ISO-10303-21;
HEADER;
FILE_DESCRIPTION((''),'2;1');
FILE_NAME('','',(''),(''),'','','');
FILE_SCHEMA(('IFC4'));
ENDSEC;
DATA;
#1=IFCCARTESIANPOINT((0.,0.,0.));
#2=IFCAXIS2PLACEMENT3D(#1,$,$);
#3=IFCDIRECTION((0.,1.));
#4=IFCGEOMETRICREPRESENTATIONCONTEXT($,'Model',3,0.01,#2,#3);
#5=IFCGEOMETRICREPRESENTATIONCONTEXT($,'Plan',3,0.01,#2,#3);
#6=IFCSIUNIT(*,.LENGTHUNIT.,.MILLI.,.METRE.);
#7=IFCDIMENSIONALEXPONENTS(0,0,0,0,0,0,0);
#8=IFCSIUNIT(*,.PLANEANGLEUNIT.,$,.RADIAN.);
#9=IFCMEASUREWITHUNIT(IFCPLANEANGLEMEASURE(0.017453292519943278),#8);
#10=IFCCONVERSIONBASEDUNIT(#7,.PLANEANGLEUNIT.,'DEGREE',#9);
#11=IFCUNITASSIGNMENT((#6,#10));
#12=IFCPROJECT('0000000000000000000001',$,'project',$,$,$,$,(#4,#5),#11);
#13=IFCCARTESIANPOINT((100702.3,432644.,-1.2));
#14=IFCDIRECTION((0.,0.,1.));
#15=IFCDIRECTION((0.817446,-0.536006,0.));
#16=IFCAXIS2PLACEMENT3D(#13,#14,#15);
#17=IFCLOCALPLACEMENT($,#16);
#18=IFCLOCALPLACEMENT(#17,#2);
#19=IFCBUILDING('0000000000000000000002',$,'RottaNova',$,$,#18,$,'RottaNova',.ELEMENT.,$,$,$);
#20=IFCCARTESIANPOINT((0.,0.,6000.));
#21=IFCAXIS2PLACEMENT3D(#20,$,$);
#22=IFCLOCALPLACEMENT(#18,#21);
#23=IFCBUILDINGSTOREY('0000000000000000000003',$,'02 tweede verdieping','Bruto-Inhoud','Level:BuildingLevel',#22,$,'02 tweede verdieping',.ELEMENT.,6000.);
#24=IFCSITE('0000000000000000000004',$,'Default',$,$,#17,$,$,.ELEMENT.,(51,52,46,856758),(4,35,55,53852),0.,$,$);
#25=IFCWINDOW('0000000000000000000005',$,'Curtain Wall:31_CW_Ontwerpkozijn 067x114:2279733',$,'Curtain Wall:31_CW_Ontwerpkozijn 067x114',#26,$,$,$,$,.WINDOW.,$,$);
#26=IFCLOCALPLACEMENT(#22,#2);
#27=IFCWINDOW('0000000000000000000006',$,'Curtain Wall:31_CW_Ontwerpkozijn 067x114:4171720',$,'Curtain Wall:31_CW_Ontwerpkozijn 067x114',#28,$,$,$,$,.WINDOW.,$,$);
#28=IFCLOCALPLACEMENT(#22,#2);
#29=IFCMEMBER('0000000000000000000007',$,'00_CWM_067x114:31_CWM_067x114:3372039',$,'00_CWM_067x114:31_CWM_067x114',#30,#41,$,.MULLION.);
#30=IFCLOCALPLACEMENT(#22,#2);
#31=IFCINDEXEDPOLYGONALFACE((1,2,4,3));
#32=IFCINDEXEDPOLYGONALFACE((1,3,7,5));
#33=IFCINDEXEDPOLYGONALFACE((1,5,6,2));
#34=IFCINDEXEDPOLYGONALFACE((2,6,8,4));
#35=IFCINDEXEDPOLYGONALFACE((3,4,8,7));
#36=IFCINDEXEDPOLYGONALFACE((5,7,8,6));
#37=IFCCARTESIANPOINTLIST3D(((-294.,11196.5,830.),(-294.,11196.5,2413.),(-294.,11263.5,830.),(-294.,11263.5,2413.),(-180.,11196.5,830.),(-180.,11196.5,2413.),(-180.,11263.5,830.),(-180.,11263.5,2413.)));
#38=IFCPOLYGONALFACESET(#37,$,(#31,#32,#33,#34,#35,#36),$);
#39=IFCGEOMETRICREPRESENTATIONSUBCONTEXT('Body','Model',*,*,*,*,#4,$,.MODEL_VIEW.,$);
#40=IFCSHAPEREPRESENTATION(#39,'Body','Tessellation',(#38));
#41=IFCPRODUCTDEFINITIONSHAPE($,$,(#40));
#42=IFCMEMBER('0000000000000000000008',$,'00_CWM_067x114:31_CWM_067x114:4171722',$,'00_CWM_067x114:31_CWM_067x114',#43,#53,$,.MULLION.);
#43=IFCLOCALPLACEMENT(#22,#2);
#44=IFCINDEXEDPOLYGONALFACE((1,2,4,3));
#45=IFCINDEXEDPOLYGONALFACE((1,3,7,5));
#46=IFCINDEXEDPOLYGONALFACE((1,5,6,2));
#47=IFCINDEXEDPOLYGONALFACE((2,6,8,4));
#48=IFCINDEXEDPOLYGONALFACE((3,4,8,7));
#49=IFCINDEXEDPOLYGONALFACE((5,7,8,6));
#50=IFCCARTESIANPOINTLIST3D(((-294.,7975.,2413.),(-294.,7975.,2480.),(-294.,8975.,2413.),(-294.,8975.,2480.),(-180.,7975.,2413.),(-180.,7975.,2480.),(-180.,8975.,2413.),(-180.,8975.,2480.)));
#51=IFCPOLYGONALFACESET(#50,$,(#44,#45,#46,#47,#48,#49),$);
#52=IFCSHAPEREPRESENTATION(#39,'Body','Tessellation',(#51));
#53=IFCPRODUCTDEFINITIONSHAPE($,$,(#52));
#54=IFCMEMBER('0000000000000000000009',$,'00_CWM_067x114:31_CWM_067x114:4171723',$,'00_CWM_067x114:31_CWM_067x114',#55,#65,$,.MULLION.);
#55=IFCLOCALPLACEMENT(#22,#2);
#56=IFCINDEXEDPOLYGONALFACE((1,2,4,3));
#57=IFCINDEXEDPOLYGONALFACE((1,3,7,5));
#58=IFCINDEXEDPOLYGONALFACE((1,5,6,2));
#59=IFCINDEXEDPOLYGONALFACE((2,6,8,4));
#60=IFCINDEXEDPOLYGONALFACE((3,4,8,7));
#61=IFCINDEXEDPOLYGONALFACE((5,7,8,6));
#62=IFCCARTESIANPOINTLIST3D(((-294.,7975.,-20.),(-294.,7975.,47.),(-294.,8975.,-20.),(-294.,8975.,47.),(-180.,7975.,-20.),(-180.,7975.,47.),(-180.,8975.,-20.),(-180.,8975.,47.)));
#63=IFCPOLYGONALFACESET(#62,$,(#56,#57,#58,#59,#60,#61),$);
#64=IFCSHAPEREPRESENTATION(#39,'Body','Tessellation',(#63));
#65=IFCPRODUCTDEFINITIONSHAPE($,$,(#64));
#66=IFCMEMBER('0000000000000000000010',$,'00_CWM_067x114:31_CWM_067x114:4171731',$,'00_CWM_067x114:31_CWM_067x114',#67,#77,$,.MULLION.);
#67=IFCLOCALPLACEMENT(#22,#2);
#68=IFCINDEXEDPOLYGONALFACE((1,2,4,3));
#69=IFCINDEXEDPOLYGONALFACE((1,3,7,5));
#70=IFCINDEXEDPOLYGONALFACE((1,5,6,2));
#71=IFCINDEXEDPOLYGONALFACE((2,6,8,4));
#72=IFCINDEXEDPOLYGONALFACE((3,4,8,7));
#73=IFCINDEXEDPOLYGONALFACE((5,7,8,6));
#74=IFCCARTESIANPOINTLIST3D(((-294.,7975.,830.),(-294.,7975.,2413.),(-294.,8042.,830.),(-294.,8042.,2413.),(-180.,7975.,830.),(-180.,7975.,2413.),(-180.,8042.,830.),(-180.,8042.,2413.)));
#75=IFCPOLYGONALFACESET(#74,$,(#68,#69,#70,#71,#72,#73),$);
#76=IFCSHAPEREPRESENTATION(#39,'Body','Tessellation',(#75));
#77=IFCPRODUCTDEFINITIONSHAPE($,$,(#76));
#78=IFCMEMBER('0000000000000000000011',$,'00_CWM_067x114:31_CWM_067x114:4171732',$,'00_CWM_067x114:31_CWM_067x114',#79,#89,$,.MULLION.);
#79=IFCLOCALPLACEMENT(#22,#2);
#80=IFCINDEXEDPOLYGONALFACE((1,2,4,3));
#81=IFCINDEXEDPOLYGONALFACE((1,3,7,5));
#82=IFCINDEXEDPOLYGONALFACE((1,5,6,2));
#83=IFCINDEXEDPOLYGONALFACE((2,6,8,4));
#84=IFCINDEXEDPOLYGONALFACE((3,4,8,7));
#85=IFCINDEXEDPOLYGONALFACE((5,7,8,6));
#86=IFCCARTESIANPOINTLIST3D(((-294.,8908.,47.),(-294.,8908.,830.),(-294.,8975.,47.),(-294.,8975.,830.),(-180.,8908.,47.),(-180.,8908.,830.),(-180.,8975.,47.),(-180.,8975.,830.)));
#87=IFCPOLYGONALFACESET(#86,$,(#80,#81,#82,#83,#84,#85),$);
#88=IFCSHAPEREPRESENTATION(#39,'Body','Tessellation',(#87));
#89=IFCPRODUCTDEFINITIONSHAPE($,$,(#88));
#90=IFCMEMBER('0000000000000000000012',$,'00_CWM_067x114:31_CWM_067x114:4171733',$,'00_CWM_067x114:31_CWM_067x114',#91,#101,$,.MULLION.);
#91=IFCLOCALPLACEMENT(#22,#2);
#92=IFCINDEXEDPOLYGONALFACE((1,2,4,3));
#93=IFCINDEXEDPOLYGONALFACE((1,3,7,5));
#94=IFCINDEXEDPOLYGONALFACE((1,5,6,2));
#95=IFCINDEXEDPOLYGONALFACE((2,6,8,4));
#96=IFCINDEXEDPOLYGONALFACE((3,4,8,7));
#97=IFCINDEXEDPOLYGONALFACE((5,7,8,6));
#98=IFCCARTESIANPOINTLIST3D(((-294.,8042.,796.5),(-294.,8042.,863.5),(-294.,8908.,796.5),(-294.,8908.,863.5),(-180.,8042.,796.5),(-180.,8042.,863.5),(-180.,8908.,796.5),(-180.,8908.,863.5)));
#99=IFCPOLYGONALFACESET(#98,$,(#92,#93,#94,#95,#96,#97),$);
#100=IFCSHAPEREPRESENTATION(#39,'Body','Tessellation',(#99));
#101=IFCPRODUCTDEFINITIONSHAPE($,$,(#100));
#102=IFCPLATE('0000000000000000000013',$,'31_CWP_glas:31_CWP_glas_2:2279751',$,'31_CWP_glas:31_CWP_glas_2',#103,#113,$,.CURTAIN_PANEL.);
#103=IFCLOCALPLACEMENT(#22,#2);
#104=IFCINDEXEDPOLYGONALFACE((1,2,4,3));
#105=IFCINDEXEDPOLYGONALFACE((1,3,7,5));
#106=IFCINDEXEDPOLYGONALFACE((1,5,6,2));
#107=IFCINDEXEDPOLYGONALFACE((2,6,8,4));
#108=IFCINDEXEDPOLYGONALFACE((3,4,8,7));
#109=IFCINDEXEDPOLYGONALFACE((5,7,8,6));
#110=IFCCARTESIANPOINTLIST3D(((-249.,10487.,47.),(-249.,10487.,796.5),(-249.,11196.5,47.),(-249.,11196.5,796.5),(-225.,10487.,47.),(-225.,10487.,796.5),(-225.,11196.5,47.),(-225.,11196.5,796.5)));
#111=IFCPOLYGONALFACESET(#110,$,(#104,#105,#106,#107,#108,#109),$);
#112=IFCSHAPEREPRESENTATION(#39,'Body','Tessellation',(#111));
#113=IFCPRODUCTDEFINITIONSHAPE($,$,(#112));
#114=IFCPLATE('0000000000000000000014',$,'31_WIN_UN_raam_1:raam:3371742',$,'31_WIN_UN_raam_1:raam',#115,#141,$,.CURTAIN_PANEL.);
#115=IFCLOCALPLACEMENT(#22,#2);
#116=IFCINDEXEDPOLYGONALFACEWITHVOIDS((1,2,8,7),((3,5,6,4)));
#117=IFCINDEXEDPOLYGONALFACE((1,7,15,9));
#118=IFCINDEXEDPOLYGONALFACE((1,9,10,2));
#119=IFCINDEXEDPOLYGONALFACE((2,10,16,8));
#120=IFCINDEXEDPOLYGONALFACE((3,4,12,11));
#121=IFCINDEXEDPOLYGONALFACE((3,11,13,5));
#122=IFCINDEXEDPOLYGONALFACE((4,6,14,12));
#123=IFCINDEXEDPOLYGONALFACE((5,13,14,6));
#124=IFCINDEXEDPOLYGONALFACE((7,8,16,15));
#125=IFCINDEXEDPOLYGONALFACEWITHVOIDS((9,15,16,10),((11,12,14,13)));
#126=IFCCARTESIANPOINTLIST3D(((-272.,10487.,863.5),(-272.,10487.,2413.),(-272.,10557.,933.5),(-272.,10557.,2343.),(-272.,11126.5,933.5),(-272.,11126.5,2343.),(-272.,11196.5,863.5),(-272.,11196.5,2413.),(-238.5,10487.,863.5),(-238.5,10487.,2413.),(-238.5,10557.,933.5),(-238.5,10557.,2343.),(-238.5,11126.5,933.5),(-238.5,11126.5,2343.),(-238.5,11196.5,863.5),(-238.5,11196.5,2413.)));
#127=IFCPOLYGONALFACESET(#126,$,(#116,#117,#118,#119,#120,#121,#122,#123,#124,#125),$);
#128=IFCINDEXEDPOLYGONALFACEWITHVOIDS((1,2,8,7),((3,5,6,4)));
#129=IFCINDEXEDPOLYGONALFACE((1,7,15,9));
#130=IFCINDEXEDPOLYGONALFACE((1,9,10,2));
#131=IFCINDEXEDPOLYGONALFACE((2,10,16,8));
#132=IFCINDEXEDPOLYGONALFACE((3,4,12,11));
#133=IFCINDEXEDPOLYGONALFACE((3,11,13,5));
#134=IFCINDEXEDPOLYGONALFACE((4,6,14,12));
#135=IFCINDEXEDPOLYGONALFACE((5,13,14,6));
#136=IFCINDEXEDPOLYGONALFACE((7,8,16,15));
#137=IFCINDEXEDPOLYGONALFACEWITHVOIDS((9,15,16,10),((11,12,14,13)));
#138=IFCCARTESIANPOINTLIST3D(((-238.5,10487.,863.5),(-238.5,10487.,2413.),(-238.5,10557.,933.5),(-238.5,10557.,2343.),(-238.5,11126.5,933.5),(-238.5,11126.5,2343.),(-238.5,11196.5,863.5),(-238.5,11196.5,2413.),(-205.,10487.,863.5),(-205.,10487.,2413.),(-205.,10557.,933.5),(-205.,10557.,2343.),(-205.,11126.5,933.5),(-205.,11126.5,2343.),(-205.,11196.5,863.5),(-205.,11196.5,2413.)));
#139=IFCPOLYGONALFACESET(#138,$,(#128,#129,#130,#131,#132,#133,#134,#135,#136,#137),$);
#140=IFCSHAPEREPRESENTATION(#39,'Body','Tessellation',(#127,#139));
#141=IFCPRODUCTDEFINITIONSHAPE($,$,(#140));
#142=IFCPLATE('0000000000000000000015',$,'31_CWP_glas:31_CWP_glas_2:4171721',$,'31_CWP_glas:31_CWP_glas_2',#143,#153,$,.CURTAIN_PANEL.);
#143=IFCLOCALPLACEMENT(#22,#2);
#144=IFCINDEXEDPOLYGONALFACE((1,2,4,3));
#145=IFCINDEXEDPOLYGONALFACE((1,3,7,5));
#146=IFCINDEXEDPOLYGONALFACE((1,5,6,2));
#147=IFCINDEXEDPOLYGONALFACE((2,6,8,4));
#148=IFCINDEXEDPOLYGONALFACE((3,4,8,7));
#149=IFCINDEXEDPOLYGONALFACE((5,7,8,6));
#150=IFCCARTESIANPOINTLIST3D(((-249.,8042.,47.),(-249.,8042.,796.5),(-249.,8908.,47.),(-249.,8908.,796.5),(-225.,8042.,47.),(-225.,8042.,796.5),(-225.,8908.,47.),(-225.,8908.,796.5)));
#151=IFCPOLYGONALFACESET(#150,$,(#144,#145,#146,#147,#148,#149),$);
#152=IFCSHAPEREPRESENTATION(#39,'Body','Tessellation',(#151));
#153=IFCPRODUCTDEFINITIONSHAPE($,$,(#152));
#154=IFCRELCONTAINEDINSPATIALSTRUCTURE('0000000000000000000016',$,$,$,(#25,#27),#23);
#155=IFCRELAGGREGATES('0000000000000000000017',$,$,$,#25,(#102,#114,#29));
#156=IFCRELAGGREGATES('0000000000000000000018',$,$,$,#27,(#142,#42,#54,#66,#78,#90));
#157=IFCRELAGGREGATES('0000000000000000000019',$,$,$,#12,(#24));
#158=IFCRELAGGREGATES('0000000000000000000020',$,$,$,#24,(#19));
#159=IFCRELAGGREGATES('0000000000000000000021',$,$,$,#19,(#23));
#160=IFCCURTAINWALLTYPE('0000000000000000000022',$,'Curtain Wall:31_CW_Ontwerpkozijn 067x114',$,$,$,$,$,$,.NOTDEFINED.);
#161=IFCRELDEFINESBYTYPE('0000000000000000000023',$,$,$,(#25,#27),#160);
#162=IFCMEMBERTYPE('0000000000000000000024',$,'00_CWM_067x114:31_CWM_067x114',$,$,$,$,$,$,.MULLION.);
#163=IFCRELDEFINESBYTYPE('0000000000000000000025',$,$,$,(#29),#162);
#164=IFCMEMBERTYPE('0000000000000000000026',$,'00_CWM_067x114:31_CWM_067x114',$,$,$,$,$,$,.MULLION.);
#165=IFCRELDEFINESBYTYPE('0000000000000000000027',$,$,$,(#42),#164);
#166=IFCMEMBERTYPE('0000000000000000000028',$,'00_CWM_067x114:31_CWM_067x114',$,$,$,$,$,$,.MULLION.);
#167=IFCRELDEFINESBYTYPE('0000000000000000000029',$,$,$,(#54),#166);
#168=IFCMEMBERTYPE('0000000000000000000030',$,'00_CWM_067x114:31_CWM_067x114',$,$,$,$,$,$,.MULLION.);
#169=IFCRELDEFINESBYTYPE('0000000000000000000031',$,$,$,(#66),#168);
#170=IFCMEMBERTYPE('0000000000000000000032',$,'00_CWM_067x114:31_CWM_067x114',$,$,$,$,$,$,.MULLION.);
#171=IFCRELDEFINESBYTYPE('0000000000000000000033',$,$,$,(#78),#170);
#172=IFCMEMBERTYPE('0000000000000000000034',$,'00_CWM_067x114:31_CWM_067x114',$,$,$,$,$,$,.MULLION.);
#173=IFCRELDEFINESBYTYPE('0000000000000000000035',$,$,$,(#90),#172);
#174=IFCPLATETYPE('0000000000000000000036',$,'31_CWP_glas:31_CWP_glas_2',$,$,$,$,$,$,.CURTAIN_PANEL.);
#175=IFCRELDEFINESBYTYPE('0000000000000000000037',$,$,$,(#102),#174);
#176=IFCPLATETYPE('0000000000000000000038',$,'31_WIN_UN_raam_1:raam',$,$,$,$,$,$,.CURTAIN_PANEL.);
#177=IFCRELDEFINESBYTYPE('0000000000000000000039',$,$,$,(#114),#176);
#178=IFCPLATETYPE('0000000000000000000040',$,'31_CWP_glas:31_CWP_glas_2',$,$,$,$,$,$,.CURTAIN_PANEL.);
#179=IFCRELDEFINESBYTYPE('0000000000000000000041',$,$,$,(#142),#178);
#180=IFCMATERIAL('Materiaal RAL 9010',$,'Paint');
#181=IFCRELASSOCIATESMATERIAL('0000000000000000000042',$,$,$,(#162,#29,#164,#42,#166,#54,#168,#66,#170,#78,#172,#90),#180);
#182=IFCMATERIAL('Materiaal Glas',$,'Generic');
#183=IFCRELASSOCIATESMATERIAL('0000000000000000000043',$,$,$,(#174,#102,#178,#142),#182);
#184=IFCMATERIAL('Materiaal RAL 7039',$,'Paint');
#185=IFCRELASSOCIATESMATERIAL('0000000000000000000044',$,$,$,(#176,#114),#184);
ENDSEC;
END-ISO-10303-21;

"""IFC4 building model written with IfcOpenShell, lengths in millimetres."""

from ifc_helpers import new_model, entity, si_unit, converted_unit, direction, frame, origin, place, context, subcontext, project, spatial, indexed_curve, outline, extrude, source, transform, mapped, material, type_object, type_shapes, element, aggregate, save


model = new_model("IFC4")

# Units and contexts
model_context = context("Model", 3, precision=0.01, world=origin(), true_north=direction((0.0, 1.0)))
plan_context = context("Plan", 3, precision=0.01, world=origin(), true_north=direction((0.0, 1.0)))
body_context = subcontext(model_context, "Body", "Model", "MODEL_VIEW")
ifc_project = project(units=[si_unit("LENGTHUNIT", "METRE", prefix="MILLI"), converted_unit("PLANEANGLEUNIT", "DEGREE", entity("IfcPlaneAngleMeasure", 0.017453292519943278), si_unit("PLANEANGLEUNIT", "RADIAN"), dimensions=[0, 0, 0, 0, 0, 0, 0])], contexts=[model_context, plan_context])

# Site, building, storey
site_placement = place(None, frame((100702.3, 432644.0, -1.2), z_axis=(0.0, 0.0, 1.0), x_axis=(0.817446, -0.536006, 0.0)))
site = spatial("IfcSite", under=ifc_project, at=site_placement, Name="Default", CompositionType="ELEMENT", RefLatitude=(51, 52, 46, 856758), RefLongitude=(4, 35, 55, 53852), RefElevation=0.0)
building_placement = place(site_placement, origin())
building = spatial("IfcBuilding", under=site, at=building_placement, Name="RottaNova", LongName="RottaNova", CompositionType="ELEMENT")
storey_placement = place(building_placement, frame((0.0, 0.0, 6000.0)))
storey = spatial("IfcBuildingStorey", under=building, at=storey_placement, Name="02 tweede verdieping", Description="Bruto-Inhoud", ObjectType="Level:BuildingLevel", LongName="02 tweede verdieping", CompositionType="ELEMENT", Elevation=6000.0)

# Windows
curtain_wall_type = type_object("IfcCurtainWallType", Name="Curtain Wall:31_CW_Ontwerpkozijn 067x114", PredefinedType="NOTDEFINED")
window_1_placement = place(storey_placement, frame((0.0, 0.0, -6000.0)))
window_1 = element("IfcWindow", 1, at=window_1_placement, inside=storey, type_object=curtain_wall_type, Name="Curtain Wall:31_CW_Ontwerpkozijn 067x114:2279733", ObjectType="Curtain Wall:31_CW_Ontwerpkozijn 067x114", PredefinedType="WINDOW")
ifc_material_1 = material(Name="Materiaal RAL 9010", Category="Paint")
window_2_placement = place(storey_placement, frame((0.0, 0.0, -6000.0)))
window_2 = element("IfcWindow", 2, at=window_2_placement, inside=storey, type_object=curtain_wall_type, Name="Curtain Wall:31_CW_Ontwerpkozijn 067x114:4171720", ObjectType="Curtain Wall:31_CW_Ontwerpkozijn 067x114", PredefinedType="WINDOW")

# Members
member_type_1 = type_object("IfcMemberType", Name="00_CWM_067x114:31_CWM_067x114", PredefinedType="MULLION", material=ifc_material_1)
shared_shape_1 = source(origin(), body_context, "Body", "SweptSolid", [
    extrude(outline(indexed_curve([(-33.5, -57.0), (33.5, -57.0), (33.5, 57.0), (-33.5, 57.0), (-33.5, -57.0)], self_intersect=False)), frame((0.0, 57.0, -1583.0), z_axis=(0.0, 0.0, 1.0), x_axis=(-1.0, 0.0, 0.0)), (0.0, 0.0, 1.0), 1583.0),
])
type_shapes(member_type_1, [shared_shape_1])
member_1_placement = place(window_1_placement, frame((-180.0, 11230.0, 6830.0), z_axis=(0.0, 0.0, -1.0), x_axis=(0.0, -1.0, 0.0)))
member_1 = element("IfcMember", 3, at=member_1_placement, type_object=member_type_1, material=ifc_material_1, Name="00_CWM_067x114:31_CWM_067x114:3372039", ObjectType="00_CWM_067x114:31_CWM_067x114", PredefinedType="MULLION", context=body_context, shape_type="MappedRepresentation", body=[
    mapped(shared_shape_1, transform((0.0, 0.0, 0.0), scale=1.0)),
])
member_type_2 = type_object("IfcMemberType", Name="00_CWM_067x114:31_CWM_067x114", PredefinedType="MULLION", material=ifc_material_1)
shared_shape_2 = source(origin(), body_context, "Body", "SweptSolid", [
    extrude(outline(indexed_curve([(-33.5, -57.0), (33.5, -57.0), (33.5, 57.0), (-33.5, 57.0), (-33.5, -57.0)], self_intersect=False)), frame((-33.5, 57.0, -1000.0), z_axis=(0.0, 0.0, 1.0), x_axis=(-1.0, 0.0, 0.0)), (0.0, 0.0, 1.0), 1000.0),
])
type_shapes(member_type_2, [shared_shape_2])
member_2_placement = place(window_2_placement, frame((-180.0, 7975.0, 8480.0), z_axis=(0.0, -1.0, 0.0), x_axis=(0.0, 0.0, 1.0)))
member_2 = element("IfcMember", 4, at=member_2_placement, type_object=member_type_2, material=ifc_material_1, Name="00_CWM_067x114:31_CWM_067x114:4171722", ObjectType="00_CWM_067x114:31_CWM_067x114", PredefinedType="MULLION", context=body_context, shape_type="MappedRepresentation", body=[
    mapped(shared_shape_2, transform((0.0, 0.0, 0.0), scale=1.0)),
])
member_type_3 = type_object("IfcMemberType", Name="00_CWM_067x114:31_CWM_067x114", PredefinedType="MULLION", material=ifc_material_1)
shared_shape_3 = source(origin(), body_context, "Body", "SweptSolid", [
    extrude(outline(indexed_curve([(-33.5, -57.0), (33.5, -57.0), (33.5, 57.0), (-33.5, 57.0), (-33.5, -57.0)], self_intersect=False)), frame((-33.5, 57.0, -1000.0), z_axis=(0.0, 0.0, 1.0), x_axis=(-1.0, 0.0, 0.0)), (0.0, 0.0, 1.0), 1000.0),
])
type_shapes(member_type_3, [shared_shape_3])
member_3_placement = place(window_2_placement, frame((-180.0, 8975.0, 5980.0), z_axis=(0.0, 1.0, 0.0), x_axis=(0.0, 0.0, -1.0)))
member_3 = element("IfcMember", 5, at=member_3_placement, type_object=member_type_3, material=ifc_material_1, Name="00_CWM_067x114:31_CWM_067x114:4171723", ObjectType="00_CWM_067x114:31_CWM_067x114", PredefinedType="MULLION", context=body_context, shape_type="MappedRepresentation", body=[
    mapped(shared_shape_3, transform((0.0, 0.0, 0.0), scale=1.0)),
])
member_type_4 = type_object("IfcMemberType", Name="00_CWM_067x114:31_CWM_067x114", PredefinedType="MULLION", material=ifc_material_1)
shared_shape_4 = source(origin(), body_context, "Body", "SweptSolid", [
    extrude(outline(indexed_curve([(-33.5, -57.0), (33.5, -57.0), (33.5, 57.0), (-33.5, 57.0), (-33.5, -57.0)], self_intersect=False)), frame((-33.5, 57.0, -1583.0), z_axis=(0.0, 0.0, 1.0), x_axis=(-1.0, 0.0, 0.0)), (0.0, 0.0, 1.0), 1583.0),
])
type_shapes(member_type_4, [shared_shape_4])
member_4_placement = place(window_2_placement, frame((-180.0, 7975.0, 6830.0), z_axis=(0.0, 0.0, -1.0), x_axis=(0.0, -1.0, 0.0)))
member_4 = element("IfcMember", 6, at=member_4_placement, type_object=member_type_4, material=ifc_material_1, Name="00_CWM_067x114:31_CWM_067x114:4171731", ObjectType="00_CWM_067x114:31_CWM_067x114", PredefinedType="MULLION", context=body_context, shape_type="MappedRepresentation", body=[
    mapped(shared_shape_4, transform((0.0, 0.0, 0.0), scale=1.0)),
])
member_type_5 = type_object("IfcMemberType", Name="00_CWM_067x114:31_CWM_067x114", PredefinedType="MULLION", material=ifc_material_1)
shared_shape_5 = source(origin(), body_context, "Body", "SweptSolid", [
    extrude(outline(indexed_curve([(-33.5, -57.0), (33.5, -57.0), (33.5, 57.0), (-33.5, 57.0), (-33.5, -57.0)], self_intersect=False)), frame((-33.5, 57.0, -783.0), z_axis=(0.0, 0.0, 1.0), x_axis=(-1.0, 0.0, 0.0)), (0.0, 0.0, 1.0), 783.0),
])
type_shapes(member_type_5, [shared_shape_5])
member_5_placement = place(window_2_placement, frame((-180.0, 8975.0, 6830.0), z_axis=(0.0, 0.0, 1.0), x_axis=(0.0, 1.0, 0.0)))
member_5 = element("IfcMember", 7, at=member_5_placement, type_object=member_type_5, material=ifc_material_1, Name="00_CWM_067x114:31_CWM_067x114:4171732", ObjectType="00_CWM_067x114:31_CWM_067x114", PredefinedType="MULLION", context=body_context, shape_type="MappedRepresentation", body=[
    mapped(shared_shape_5, transform((0.0, 0.0, 0.0), scale=1.0)),
])
member_type_6 = type_object("IfcMemberType", Name="00_CWM_067x114:31_CWM_067x114", PredefinedType="MULLION", material=ifc_material_1)
shared_shape_6 = source(origin(), body_context, "Body", "SweptSolid", [
    extrude(outline(indexed_curve([(-33.5, -57.0), (33.5, -57.0), (33.5, 57.0), (-33.5, 57.0), (-33.5, -57.0)], self_intersect=False)), frame((0.0, 57.0, -866.0), z_axis=(0.0, 0.0, 1.0), x_axis=(-1.0, 0.0, 0.0)), (0.0, 0.0, 1.0), 866.0),
])
type_shapes(member_type_6, [shared_shape_6])
member_6_placement = place(window_2_placement, frame((-180.0, 8042.0, 6830.0), z_axis=(0.0, -1.0, 0.0), x_axis=(0.0, 0.0, 1.0)))
member_6 = element("IfcMember", 8, at=member_6_placement, type_object=member_type_6, material=ifc_material_1, Name="00_CWM_067x114:31_CWM_067x114:4171733", ObjectType="00_CWM_067x114:31_CWM_067x114", PredefinedType="MULLION", context=body_context, shape_type="MappedRepresentation", body=[
    mapped(shared_shape_6, transform((0.0, 0.0, 0.0), scale=1.0)),
])

# Plates
ifc_material_2 = material(Name="Materiaal Glas", Category="Generic")
plate_type_1 = type_object("IfcPlateType", Name="31_CWP_glas:31_CWP_glas_2", PredefinedType="CURTAIN_PANEL", material=ifc_material_2)
shared_shape_7 = source(origin(), body_context, "Body", "SweptSolid", [
    extrude(outline(indexed_curve([(-12.0, -354.8), (12.0, -354.8), (12.0, 354.8), (-12.0, 354.8), (-12.0, -354.8)], self_intersect=False)), frame((0.0, -57.0, 0.0), z_axis=(0.0, 0.0, 1.0), x_axis=(0.0, 1.0, 0.0)), (0.0, 0.0, 1.0), 749.5),
])
type_shapes(plate_type_1, [shared_shape_7])
plate_1_placement = place(window_1_placement, frame((-180.0, 10841.7, 6047.0), z_axis=(0.0, 0.0, 1.0), x_axis=(0.0, -1.0, 0.0)))
plate_1 = element("IfcPlate", 9, at=plate_1_placement, type_object=plate_type_1, material=ifc_material_2, Name="31_CWP_glas:31_CWP_glas_2:2279751", ObjectType="31_CWP_glas:31_CWP_glas_2", PredefinedType="CURTAIN_PANEL", context=body_context, shape_type="MappedRepresentation", body=[
    mapped(shared_shape_7, transform((0.0, 0.0, 0.0), scale=1.0)),
])
ifc_material_3 = material(Name="Materiaal RAL 7039", Category="Paint")
plate_type_2 = type_object("IfcPlateType", Name="31_WIN_UN_raam_1:raam", PredefinedType="CURTAIN_PANEL", material=ifc_material_3)
shared_shape_8 = source(origin(), body_context, "Body", "SweptSolid", [
    extrude(outline(indexed_curve([(-354.7, -774.7), (354.7, -774.7), (354.7, 774.7), (-354.7, 774.7), (-354.7, -774.7)], self_intersect=False), holes=[indexed_curve([(-284.7, 704.7), (284.7, 704.7), (284.7, -704.8), (-284.7, -704.8), (-284.7, 704.7)], self_intersect=False)]), frame((0.0, -92.0, 774.8), z_axis=(0.0, 1.0, 0.0), x_axis=(1.0, 0.0, 0.0)), (0.0, 0.0, 1.0), 33.5),
    extrude(outline(indexed_curve([(-354.7, -774.7), (354.7, -774.7), (354.7, 774.7), (-354.7, 774.7), (-354.7, -774.7)], self_intersect=False), holes=[indexed_curve([(-284.7, 704.7), (284.7, 704.7), (284.7, -704.8), (-284.7, -704.8), (-284.7, 704.7)], self_intersect=False)]), frame((0.0, -58.5, 774.8), z_axis=(0.0, 1.0, 0.0), x_axis=(1.0, 0.0, 0.0)), (0.0, 0.0, 1.0), 33.5),
])
type_shapes(plate_type_2, [shared_shape_8])
plate_2_placement = place(window_1_placement, frame((-180.0, 10841.7, 6863.5), z_axis=(0.0, 0.0, 1.0), x_axis=(0.0, -1.0, 0.0)))
plate_2 = element("IfcPlate", 10, at=plate_2_placement, type_object=plate_type_2, material=ifc_material_3, Name="31_WIN_UN_raam_1:raam:3371742", ObjectType="31_WIN_UN_raam_1:raam", PredefinedType="CURTAIN_PANEL", context=body_context, shape_type="MappedRepresentation", body=[
    mapped(shared_shape_8, transform((0.0, 0.0, 0.0), scale=1.0)),
])
aggregate(window_1, [plate_1, plate_2, member_1])
plate_type_3 = type_object("IfcPlateType", Name="31_CWP_glas:31_CWP_glas_2", PredefinedType="CURTAIN_PANEL", material=ifc_material_2)
shared_shape_9 = source(origin(), body_context, "Body", "SweptSolid", [
    extrude(outline(indexed_curve([(-12.0, -433.0), (12.0, -433.0), (12.0, 433.0), (-12.0, 433.0), (-12.0, -433.0)], self_intersect=False)), frame((0.0, -57.0, 0.0), z_axis=(0.0, 0.0, 1.0), x_axis=(0.0, 1.0, 0.0)), (0.0, 0.0, 1.0), 749.5),
])
type_shapes(plate_type_3, [shared_shape_9])
plate_3_placement = place(window_2_placement, frame((-180.0, 8475.0, 6047.0), z_axis=(0.0, 0.0, 1.0), x_axis=(0.0, -1.0, 0.0)))
plate_3 = element("IfcPlate", 11, at=plate_3_placement, type_object=plate_type_3, material=ifc_material_2, Name="31_CWP_glas:31_CWP_glas_2:4171721", ObjectType="31_CWP_glas:31_CWP_glas_2", PredefinedType="CURTAIN_PANEL", context=body_context, shape_type="MappedRepresentation", body=[
    mapped(shared_shape_9, transform((0.0, 0.0, 0.0), scale=1.0)),
])
aggregate(window_2, [plate_3, member_2, member_3, member_4, member_5, member_6])

save(model, "model.ifc")
